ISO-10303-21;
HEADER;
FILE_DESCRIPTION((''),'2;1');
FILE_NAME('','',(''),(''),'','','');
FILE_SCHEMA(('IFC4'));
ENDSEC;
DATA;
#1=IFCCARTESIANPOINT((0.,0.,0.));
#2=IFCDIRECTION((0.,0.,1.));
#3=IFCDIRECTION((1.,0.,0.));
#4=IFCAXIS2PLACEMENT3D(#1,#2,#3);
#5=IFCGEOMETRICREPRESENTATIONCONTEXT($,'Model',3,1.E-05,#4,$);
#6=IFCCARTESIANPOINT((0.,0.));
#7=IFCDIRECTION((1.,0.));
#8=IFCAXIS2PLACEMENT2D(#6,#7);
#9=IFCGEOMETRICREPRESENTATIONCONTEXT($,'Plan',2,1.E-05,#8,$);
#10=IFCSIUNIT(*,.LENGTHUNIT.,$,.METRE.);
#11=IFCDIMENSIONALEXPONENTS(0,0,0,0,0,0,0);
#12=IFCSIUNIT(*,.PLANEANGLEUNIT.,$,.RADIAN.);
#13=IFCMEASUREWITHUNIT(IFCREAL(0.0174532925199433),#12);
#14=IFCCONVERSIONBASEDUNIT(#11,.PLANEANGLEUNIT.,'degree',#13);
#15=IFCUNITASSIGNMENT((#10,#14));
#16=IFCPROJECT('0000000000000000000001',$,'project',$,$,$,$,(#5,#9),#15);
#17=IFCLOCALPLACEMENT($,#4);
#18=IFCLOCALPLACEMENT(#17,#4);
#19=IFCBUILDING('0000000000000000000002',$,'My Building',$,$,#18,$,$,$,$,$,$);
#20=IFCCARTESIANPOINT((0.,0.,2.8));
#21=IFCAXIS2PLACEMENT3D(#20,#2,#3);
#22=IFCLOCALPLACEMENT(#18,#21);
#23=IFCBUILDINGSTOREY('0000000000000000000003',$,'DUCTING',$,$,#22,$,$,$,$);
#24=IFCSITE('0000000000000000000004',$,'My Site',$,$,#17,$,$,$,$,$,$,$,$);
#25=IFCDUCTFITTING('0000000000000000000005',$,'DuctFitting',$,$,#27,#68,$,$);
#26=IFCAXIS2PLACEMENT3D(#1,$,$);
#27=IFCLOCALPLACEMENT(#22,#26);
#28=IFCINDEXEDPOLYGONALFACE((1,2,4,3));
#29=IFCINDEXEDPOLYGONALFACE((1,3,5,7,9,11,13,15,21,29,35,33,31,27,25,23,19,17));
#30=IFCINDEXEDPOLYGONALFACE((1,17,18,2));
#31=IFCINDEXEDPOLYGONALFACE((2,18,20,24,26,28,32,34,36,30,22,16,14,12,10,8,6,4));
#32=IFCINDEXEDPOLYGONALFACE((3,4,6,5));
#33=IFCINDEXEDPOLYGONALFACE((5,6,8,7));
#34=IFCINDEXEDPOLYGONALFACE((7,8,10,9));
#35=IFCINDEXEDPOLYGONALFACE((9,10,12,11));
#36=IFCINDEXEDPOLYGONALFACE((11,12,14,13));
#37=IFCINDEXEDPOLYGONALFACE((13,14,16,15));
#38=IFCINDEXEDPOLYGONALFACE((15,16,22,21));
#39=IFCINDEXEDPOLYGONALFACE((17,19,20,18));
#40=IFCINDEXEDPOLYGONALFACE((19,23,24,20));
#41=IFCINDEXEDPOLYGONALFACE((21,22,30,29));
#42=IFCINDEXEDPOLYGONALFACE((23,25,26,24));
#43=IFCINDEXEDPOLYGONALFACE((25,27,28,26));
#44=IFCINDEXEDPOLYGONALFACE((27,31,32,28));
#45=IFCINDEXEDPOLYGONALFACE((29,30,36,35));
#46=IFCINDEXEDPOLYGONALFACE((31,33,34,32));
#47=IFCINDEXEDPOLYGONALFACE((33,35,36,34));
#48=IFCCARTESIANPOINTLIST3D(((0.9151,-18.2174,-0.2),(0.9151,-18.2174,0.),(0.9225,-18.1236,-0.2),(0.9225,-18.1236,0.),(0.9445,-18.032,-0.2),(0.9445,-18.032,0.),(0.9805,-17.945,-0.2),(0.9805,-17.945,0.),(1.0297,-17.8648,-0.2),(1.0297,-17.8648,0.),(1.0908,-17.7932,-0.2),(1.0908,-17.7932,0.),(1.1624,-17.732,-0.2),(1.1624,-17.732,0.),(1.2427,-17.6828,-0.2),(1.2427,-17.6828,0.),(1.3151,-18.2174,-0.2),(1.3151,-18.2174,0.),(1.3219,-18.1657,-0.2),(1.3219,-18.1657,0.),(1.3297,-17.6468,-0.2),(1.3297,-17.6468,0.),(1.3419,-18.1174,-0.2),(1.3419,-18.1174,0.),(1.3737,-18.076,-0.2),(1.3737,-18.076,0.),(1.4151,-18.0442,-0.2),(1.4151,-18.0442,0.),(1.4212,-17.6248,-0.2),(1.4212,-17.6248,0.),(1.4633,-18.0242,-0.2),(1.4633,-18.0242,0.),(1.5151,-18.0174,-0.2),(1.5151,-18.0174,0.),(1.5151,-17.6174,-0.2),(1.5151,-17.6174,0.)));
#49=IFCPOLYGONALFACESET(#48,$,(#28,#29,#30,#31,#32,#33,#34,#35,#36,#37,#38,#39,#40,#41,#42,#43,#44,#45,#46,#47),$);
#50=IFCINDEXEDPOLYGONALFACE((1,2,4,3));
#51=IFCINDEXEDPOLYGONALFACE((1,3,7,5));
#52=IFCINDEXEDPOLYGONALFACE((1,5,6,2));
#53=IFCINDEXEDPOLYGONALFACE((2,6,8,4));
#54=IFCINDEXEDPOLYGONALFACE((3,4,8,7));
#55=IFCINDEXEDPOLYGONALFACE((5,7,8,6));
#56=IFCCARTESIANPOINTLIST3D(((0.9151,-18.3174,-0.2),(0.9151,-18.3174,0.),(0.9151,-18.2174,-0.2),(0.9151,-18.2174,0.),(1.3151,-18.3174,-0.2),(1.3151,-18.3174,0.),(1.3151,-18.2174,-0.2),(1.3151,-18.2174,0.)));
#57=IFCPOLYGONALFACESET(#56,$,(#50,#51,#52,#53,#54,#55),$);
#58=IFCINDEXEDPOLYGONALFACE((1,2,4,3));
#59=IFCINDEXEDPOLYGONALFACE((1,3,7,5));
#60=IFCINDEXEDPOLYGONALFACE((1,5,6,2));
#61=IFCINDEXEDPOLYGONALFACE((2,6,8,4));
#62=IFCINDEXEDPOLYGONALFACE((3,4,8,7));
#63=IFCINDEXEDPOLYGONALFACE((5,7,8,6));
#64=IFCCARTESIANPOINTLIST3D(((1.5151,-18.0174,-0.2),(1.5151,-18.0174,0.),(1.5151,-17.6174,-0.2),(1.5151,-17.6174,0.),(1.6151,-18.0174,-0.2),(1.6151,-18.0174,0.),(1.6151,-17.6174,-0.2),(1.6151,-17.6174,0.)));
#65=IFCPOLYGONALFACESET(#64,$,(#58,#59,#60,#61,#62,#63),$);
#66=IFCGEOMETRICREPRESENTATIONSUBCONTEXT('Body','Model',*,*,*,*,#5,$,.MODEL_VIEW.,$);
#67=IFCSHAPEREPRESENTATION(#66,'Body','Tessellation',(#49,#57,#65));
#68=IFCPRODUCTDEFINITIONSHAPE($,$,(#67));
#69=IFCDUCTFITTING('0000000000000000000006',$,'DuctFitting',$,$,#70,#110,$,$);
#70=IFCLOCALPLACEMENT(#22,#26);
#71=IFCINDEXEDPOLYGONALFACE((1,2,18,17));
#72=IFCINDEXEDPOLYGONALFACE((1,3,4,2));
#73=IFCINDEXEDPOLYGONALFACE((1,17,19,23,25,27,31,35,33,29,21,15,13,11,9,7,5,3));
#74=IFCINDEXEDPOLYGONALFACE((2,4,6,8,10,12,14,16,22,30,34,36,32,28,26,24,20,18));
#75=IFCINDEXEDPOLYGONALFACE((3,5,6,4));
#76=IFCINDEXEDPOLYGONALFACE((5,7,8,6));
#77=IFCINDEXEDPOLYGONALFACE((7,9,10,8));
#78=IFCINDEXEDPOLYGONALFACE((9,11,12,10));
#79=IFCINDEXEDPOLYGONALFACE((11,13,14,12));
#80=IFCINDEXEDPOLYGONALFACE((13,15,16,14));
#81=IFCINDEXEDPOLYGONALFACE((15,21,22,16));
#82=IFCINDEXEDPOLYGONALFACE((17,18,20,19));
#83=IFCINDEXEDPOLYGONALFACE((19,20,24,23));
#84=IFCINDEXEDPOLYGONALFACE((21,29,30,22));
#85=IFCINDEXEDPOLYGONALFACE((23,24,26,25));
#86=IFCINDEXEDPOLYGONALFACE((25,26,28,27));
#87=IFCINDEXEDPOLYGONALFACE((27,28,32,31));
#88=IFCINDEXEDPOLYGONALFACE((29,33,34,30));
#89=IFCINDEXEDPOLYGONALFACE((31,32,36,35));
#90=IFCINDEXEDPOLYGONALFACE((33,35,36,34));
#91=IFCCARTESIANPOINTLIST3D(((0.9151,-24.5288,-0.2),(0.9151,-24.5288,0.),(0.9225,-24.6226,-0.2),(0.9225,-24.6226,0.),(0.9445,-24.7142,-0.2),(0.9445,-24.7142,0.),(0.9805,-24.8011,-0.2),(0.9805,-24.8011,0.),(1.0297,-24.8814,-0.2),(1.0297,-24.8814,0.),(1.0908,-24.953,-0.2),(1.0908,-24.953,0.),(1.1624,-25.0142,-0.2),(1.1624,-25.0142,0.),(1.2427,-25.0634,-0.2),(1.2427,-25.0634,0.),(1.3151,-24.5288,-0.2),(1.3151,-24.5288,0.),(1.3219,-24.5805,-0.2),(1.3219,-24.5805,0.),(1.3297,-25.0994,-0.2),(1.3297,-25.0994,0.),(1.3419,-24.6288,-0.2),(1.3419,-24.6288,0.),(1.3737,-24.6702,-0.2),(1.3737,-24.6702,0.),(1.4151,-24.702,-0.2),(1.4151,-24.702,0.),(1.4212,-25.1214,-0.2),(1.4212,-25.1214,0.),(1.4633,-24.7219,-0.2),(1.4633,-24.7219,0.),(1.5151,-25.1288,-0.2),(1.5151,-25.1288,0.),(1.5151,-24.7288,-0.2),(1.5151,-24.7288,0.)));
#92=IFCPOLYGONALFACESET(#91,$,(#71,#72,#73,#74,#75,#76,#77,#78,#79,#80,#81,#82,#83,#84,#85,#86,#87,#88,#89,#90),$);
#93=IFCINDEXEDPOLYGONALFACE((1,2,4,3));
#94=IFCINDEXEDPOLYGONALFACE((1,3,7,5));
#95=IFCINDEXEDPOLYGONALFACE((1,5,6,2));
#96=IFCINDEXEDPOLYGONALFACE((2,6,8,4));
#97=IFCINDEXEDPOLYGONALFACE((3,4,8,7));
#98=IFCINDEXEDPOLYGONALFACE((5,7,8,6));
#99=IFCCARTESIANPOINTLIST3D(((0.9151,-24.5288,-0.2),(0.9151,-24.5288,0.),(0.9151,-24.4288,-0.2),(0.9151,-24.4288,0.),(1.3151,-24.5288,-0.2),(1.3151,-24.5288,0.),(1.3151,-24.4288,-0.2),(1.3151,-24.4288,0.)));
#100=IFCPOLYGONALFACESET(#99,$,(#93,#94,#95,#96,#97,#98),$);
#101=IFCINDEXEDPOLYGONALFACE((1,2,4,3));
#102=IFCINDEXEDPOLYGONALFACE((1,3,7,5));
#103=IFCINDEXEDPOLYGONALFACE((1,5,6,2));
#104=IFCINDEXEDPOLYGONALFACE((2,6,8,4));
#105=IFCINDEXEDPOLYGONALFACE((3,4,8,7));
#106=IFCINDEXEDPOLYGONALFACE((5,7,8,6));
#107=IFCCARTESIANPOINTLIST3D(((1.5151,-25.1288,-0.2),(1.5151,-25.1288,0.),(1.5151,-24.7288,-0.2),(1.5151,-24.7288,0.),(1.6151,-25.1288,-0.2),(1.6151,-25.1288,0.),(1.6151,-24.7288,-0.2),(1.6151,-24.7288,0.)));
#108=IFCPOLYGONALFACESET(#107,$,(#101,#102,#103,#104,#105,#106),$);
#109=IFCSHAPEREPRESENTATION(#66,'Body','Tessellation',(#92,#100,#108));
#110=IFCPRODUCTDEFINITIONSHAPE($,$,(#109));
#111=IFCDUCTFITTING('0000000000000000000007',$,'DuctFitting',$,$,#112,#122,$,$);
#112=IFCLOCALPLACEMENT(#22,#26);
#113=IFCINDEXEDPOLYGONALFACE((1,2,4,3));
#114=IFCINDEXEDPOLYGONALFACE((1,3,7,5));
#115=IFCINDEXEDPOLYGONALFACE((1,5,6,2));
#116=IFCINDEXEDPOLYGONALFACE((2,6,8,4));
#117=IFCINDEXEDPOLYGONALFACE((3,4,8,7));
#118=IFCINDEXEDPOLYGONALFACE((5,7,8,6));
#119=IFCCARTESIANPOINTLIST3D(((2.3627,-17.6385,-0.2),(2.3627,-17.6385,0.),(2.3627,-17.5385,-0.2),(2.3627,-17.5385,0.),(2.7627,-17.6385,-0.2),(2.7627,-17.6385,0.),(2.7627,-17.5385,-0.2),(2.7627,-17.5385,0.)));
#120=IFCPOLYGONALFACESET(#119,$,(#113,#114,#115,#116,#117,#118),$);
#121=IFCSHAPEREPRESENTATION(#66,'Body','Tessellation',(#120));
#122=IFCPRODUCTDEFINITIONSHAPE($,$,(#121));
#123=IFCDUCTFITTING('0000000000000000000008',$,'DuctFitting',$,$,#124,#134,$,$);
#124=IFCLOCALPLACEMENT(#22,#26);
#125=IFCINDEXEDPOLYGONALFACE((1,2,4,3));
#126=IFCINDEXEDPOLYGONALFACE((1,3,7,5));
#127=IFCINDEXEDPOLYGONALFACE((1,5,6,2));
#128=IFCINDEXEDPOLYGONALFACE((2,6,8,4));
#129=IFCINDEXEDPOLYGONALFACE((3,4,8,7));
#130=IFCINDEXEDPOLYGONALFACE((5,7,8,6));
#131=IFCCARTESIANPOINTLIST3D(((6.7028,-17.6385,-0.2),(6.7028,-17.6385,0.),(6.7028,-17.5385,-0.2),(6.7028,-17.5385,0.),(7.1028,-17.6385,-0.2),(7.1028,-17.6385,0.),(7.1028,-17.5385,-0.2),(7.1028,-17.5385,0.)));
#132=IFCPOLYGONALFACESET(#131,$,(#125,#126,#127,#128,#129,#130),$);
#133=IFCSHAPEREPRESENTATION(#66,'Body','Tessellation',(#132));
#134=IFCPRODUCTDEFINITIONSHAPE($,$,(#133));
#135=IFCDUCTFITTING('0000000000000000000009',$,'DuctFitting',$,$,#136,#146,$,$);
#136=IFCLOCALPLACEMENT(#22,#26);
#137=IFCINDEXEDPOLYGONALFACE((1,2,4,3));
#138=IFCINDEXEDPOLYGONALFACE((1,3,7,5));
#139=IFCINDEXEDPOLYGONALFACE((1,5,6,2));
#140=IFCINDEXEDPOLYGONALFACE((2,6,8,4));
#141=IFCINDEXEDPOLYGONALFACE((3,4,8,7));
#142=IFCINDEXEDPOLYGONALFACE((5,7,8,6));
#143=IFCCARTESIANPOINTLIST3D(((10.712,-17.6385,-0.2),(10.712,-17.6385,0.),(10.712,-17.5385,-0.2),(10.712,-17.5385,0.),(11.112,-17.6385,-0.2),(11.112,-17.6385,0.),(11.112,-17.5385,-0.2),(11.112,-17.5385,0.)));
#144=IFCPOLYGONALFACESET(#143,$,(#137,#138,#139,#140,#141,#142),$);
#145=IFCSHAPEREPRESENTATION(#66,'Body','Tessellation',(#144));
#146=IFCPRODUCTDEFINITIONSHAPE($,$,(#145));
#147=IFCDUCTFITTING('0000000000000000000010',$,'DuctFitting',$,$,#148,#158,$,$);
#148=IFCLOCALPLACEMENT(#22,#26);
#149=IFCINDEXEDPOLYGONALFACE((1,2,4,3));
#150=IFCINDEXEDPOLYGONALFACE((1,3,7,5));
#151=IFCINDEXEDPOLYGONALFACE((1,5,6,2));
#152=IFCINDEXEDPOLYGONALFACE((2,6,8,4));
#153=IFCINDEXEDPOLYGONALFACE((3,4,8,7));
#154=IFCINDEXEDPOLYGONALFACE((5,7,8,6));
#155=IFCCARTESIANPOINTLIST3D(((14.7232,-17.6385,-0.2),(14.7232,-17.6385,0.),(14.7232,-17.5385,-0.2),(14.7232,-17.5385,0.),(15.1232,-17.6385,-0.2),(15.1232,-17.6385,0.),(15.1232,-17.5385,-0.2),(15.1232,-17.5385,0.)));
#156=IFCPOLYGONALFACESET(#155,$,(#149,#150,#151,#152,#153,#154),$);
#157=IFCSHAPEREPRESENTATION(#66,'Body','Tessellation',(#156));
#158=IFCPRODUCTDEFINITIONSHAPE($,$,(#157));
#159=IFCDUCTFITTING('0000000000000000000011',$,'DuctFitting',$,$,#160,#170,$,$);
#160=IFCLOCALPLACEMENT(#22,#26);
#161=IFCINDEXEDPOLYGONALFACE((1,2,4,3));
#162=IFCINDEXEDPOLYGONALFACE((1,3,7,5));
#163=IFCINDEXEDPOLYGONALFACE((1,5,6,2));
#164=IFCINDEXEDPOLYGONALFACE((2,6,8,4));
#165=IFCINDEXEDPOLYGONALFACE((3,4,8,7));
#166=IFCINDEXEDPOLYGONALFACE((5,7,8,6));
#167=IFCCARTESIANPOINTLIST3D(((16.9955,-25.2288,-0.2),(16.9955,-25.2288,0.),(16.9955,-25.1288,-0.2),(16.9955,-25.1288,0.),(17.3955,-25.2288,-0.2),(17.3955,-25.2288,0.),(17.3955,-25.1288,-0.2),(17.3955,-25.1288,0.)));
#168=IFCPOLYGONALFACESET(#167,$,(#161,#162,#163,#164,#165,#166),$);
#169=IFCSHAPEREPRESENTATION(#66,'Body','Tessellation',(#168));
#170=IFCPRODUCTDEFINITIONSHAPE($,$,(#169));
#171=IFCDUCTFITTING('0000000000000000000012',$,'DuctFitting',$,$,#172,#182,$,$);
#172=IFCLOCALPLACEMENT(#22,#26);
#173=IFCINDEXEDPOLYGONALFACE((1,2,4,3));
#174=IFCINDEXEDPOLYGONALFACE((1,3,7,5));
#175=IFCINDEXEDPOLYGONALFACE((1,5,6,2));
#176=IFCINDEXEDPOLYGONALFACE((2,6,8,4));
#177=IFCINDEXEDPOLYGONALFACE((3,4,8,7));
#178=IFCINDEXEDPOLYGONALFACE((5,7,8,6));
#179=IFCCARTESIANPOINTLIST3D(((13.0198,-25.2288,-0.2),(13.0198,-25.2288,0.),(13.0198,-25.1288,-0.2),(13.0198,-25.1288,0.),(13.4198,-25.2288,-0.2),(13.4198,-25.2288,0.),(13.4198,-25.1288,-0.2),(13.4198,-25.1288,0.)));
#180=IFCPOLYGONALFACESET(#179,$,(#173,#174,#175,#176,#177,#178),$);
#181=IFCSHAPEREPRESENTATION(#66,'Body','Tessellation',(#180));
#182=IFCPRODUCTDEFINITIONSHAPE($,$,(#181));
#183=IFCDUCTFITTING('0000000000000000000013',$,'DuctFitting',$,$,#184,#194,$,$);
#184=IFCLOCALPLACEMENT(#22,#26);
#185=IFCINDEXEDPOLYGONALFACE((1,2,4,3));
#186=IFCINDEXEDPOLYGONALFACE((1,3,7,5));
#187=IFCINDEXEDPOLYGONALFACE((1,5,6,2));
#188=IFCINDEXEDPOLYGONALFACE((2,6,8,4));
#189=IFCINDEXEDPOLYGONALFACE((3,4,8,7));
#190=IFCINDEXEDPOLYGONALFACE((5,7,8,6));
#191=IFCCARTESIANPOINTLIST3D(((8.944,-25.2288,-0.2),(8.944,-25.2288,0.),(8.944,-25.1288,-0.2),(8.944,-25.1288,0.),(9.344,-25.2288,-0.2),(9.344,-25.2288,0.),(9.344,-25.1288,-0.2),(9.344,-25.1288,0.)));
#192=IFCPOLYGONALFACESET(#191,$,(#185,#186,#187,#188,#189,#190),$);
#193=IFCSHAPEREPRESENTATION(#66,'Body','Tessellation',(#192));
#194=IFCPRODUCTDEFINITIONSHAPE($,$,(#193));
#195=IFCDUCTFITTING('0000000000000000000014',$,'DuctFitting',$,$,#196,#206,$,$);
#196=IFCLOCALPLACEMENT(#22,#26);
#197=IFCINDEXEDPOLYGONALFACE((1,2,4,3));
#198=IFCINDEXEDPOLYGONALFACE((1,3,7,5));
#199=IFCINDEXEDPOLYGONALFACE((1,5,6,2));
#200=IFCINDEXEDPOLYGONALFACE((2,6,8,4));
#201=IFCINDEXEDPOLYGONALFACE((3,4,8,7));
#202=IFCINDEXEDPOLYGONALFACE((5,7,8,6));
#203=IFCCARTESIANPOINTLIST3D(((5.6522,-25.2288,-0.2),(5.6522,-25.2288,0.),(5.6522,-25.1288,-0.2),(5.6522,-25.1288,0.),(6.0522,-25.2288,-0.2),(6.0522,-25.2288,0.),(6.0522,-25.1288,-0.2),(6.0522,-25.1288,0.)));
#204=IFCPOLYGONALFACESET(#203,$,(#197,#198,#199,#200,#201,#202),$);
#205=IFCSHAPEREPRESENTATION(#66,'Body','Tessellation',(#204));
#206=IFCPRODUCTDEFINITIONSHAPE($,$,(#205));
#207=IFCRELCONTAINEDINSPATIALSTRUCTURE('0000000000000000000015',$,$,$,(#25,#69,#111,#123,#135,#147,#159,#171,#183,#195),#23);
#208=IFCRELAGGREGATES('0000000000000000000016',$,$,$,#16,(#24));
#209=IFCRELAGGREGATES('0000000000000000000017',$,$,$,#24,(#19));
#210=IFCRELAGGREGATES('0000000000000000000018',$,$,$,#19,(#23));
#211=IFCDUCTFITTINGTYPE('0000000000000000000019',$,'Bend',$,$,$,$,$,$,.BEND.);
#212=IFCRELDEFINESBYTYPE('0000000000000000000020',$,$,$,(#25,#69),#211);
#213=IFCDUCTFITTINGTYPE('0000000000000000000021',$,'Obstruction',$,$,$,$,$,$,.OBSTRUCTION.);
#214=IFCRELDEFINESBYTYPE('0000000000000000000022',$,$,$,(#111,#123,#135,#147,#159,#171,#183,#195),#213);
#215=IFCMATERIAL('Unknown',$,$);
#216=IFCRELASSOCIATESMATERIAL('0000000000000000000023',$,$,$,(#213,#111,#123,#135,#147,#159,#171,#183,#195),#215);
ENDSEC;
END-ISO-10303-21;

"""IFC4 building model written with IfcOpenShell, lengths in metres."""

from ifc_helpers import new_model, entity, si_unit, converted_unit, frame, origin_with_axes, origin_2d_with_axis, place, context, subcontext, project, spatial, line, arc, indexed_curve, rectangle, outline, extrude, source, transform, mapped, material, material_profile, profile_set, profile_usage, type_object, type_shapes, element, save


model = new_model("IFC4")

# Units and contexts
model_context = context("Model", 3, precision=1e-05, world=origin_with_axes())
plan_context = context("Plan", 2, precision=1e-05, world=origin_2d_with_axis())
body_context = subcontext(model_context, "Body", "Model", "MODEL_VIEW")
ifc_project = project(units=[si_unit("LENGTHUNIT", "METRE"), converted_unit("PLANEANGLEUNIT", "degree", entity("IfcReal", 0.0174532925199433), si_unit("PLANEANGLEUNIT", "RADIAN"), dimensions=[0, 0, 0, 0, 0, 0, 0])], contexts=[model_context, plan_context])

# Site, building, storey
site_placement = place(None, origin_with_axes())
site = spatial("IfcSite", under=ifc_project, at=site_placement, Name="My Site")
building_placement = place(site_placement, origin_with_axes())
building = spatial("IfcBuilding", under=site, at=building_placement, Name="My Building")
storey_placement = place(building_placement, frame((0.0, 0.0, 2.8), z_axis=(0.0, 0.0, 1.0), x_axis=(1.0, 0.0, 0.0)))
storey = spatial("IfcBuildingStorey", under=building, at=storey_placement, Name="DUCTING")

# Shared definitions
ifc_material = material(Name="Unknown")

# Duct fittings
duct_fitting_type_1 = type_object("IfcDuctFittingType", Name="Bend", PredefinedType="BEND")
shared_shape = source(origin_with_axes(), body_context, "Body", "SweptSolid", [
    extrude(outline(indexed_curve([(0.2, 0.0), (0.2586, -0.1414), (0.4, -0.2), (0.4, -0.6), (-0.0243, -0.4243), (-0.2, 0.0)], segments=[arc(1, 2, 3), line(3, 4), arc(4, 5, 6), line(6, 1)])), frame((0.0, -0.1, -0.1), z_axis=(0.0, -1.0, 0.0), x_axis=(1.0, 0.0, 0.0)), (0.0, 0.0, -1.0), 0.2),
    extrude(rectangle(XDim=0.4, YDim=0.2), origin_with_axes(), (0.0, 0.0, -1.0), 0.1),
    extrude(rectangle(XDim=0.4, YDim=0.2), frame((0.4, 0.0, -0.5), z_axis=(1.0, 0.0, 0.0), x_axis=(0.0, 0.0, 1.0)), (0.0, 0.0, 1.0), 0.1),
])
type_shapes(duct_fitting_type_1, [shared_shape])
for number, where, z_axis, x_axis, name in (
    (1, (1.1151, -18.3174, -0.1), (0.0, -1.0, 0.0), (1.0, 0.0, 0.0), "DuctFitting"),
    (2, (1.1151, -24.4288, -0.1), (0.0, 1.0, 0.0), (1.0, 0.0, 0.0), "DuctFitting"),
):
    element("IfcDuctFitting", number, at=place(storey_placement, frame(where, z_axis=z_axis, x_axis=x_axis)), inside=storey, type_object=duct_fitting_type_1, Name=name, context=body_context, shape_type="MappedRepresentation", body=[
        mapped(shared_shape, transform((0.0, 0.0, 0.0), x_axis=(1.0, 0.0, 0.0), y_axis=(0.0, 1.0, 0.0), z_axis=(0.0, 0.0, 1.0), scale=1.0)),
    ])
ifc_material_profile_1 = material_profile(ifc_material, rectangle(XDim=0.4, YDim=0.2))
ifc_profile_set_1 = profile_set([ifc_material_profile_1])
ifc_profile_usage_1 = profile_usage(ifc_profile_set_1, cardinal=5)
duct_fitting_type_2 = type_object("IfcDuctFittingType", Name="Obstruction", PredefinedType="OBSTRUCTION", material=ifc_profile_set_1)
duct_fitting_1_placement = place(storey_placement, frame((2.5627, -17.5385, -0.1), z_axis=(0.0, -1.0, 0.0), x_axis=(1.0, 0.0, 0.0)))
element("IfcDuctFitting", 3, at=duct_fitting_1_placement, inside=storey, type_object=duct_fitting_type_2, material=ifc_profile_usage_1, Name="DuctFitting", context=body_context, shape_type="SweptSolid", body=[
    extrude(rectangle(XDim=0.4, YDim=0.2), origin_with_axes(), (0.0, 0.0, 1.0), 0.1),
])
ifc_profile_usage_2 = profile_usage(ifc_profile_set_1, cardinal=5)
duct_fitting_2_placement = place(storey_placement, frame((6.9028, -17.5385, -0.1), z_axis=(0.0, -1.0, 0.0), x_axis=(1.0, 0.0, 0.0)))
element("IfcDuctFitting", 4, at=duct_fitting_2_placement, inside=storey, type_object=duct_fitting_type_2, material=ifc_profile_usage_2, Name="DuctFitting", context=body_context, shape_type="SweptSolid", body=[
    extrude(rectangle(XDim=0.4, YDim=0.2), origin_with_axes(), (0.0, 0.0, 1.0), 0.1),
])
ifc_profile_usage_3 = profile_usage(ifc_profile_set_1, cardinal=5)
duct_fitting_3_placement = place(storey_placement, frame((10.912, -17.5385, -0.1), z_axis=(0.0, -1.0, 0.0), x_axis=(1.0, 0.0, 0.0)))
element("IfcDuctFitting", 5, at=duct_fitting_3_placement, inside=storey, type_object=duct_fitting_type_2, material=ifc_profile_usage_3, Name="DuctFitting", context=body_context, shape_type="SweptSolid", body=[
    extrude(rectangle(XDim=0.4, YDim=0.2), origin_with_axes(), (0.0, 0.0, 1.0), 0.1),
])
ifc_profile_usage_4 = profile_usage(ifc_profile_set_1, cardinal=5)
duct_fitting_4_placement = place(storey_placement, frame((14.9232, -17.5385, -0.1), z_axis=(0.0, -1.0, 0.0), x_axis=(1.0, 0.0, 0.0)))
element("IfcDuctFitting", 6, at=duct_fitting_4_placement, inside=storey, type_object=duct_fitting_type_2, material=ifc_profile_usage_4, Name="DuctFitting", context=body_context, shape_type="SweptSolid", body=[
    extrude(rectangle(XDim=0.4, YDim=0.2), origin_with_axes(), (0.0, 0.0, 1.0), 0.1),
])
ifc_profile_usage_5 = profile_usage(ifc_profile_set_1, cardinal=5)
duct_fitting_5_placement = place(storey_placement, frame((17.1955, -25.2288, -0.1), z_axis=(0.0, 1.0, 0.0), x_axis=(-1.0, 0.0, 0.0)))
element("IfcDuctFitting", 7, at=duct_fitting_5_placement, inside=storey, type_object=duct_fitting_type_2, material=ifc_profile_usage_5, Name="DuctFitting", context=body_context, shape_type="SweptSolid", body=[
    extrude(rectangle(XDim=0.4, YDim=0.2), origin_with_axes(), (0.0, 0.0, 1.0), 0.1),
])
ifc_profile_usage_6 = profile_usage(ifc_profile_set_1, cardinal=5)
duct_fitting_6_placement = place(storey_placement, frame((13.2198, -25.2288, -0.1), z_axis=(0.0, 1.0, 0.0), x_axis=(-1.0, 0.0, 0.0)))
element("IfcDuctFitting", 8, at=duct_fitting_6_placement, inside=storey, type_object=duct_fitting_type_2, material=ifc_profile_usage_6, Name="DuctFitting", context=body_context, shape_type="SweptSolid", body=[
    extrude(rectangle(XDim=0.4, YDim=0.2), origin_with_axes(), (0.0, 0.0, 1.0), 0.1),
])
ifc_profile_usage_7 = profile_usage(ifc_profile_set_1, cardinal=5)
duct_fitting_7_placement = place(storey_placement, frame((9.144, -25.2288, -0.1), z_axis=(0.0, 1.0, 0.0), x_axis=(-1.0, 0.0, 0.0)))
element("IfcDuctFitting", 9, at=duct_fitting_7_placement, inside=storey, type_object=duct_fitting_type_2, material=ifc_profile_usage_7, Name="DuctFitting", context=body_context, shape_type="SweptSolid", body=[
    extrude(rectangle(XDim=0.4, YDim=0.2), origin_with_axes(), (0.0, 0.0, 1.0), 0.1),
])
ifc_profile_usage_8 = profile_usage(ifc_profile_set_1, cardinal=5)
duct_fitting_8_placement = place(storey_placement, frame((5.8522, -25.2288, -0.1), z_axis=(0.0, 1.0, 0.0), x_axis=(-1.0, 0.0, 0.0)))
element("IfcDuctFitting", 10, at=duct_fitting_8_placement, inside=storey, type_object=duct_fitting_type_2, material=ifc_profile_usage_8, Name="DuctFitting", context=body_context, shape_type="SweptSolid", body=[
    extrude(rectangle(XDim=0.4, YDim=0.2), origin_with_axes(), (0.0, 0.0, 1.0), 0.1),
])

save(model, "model.ifc")
